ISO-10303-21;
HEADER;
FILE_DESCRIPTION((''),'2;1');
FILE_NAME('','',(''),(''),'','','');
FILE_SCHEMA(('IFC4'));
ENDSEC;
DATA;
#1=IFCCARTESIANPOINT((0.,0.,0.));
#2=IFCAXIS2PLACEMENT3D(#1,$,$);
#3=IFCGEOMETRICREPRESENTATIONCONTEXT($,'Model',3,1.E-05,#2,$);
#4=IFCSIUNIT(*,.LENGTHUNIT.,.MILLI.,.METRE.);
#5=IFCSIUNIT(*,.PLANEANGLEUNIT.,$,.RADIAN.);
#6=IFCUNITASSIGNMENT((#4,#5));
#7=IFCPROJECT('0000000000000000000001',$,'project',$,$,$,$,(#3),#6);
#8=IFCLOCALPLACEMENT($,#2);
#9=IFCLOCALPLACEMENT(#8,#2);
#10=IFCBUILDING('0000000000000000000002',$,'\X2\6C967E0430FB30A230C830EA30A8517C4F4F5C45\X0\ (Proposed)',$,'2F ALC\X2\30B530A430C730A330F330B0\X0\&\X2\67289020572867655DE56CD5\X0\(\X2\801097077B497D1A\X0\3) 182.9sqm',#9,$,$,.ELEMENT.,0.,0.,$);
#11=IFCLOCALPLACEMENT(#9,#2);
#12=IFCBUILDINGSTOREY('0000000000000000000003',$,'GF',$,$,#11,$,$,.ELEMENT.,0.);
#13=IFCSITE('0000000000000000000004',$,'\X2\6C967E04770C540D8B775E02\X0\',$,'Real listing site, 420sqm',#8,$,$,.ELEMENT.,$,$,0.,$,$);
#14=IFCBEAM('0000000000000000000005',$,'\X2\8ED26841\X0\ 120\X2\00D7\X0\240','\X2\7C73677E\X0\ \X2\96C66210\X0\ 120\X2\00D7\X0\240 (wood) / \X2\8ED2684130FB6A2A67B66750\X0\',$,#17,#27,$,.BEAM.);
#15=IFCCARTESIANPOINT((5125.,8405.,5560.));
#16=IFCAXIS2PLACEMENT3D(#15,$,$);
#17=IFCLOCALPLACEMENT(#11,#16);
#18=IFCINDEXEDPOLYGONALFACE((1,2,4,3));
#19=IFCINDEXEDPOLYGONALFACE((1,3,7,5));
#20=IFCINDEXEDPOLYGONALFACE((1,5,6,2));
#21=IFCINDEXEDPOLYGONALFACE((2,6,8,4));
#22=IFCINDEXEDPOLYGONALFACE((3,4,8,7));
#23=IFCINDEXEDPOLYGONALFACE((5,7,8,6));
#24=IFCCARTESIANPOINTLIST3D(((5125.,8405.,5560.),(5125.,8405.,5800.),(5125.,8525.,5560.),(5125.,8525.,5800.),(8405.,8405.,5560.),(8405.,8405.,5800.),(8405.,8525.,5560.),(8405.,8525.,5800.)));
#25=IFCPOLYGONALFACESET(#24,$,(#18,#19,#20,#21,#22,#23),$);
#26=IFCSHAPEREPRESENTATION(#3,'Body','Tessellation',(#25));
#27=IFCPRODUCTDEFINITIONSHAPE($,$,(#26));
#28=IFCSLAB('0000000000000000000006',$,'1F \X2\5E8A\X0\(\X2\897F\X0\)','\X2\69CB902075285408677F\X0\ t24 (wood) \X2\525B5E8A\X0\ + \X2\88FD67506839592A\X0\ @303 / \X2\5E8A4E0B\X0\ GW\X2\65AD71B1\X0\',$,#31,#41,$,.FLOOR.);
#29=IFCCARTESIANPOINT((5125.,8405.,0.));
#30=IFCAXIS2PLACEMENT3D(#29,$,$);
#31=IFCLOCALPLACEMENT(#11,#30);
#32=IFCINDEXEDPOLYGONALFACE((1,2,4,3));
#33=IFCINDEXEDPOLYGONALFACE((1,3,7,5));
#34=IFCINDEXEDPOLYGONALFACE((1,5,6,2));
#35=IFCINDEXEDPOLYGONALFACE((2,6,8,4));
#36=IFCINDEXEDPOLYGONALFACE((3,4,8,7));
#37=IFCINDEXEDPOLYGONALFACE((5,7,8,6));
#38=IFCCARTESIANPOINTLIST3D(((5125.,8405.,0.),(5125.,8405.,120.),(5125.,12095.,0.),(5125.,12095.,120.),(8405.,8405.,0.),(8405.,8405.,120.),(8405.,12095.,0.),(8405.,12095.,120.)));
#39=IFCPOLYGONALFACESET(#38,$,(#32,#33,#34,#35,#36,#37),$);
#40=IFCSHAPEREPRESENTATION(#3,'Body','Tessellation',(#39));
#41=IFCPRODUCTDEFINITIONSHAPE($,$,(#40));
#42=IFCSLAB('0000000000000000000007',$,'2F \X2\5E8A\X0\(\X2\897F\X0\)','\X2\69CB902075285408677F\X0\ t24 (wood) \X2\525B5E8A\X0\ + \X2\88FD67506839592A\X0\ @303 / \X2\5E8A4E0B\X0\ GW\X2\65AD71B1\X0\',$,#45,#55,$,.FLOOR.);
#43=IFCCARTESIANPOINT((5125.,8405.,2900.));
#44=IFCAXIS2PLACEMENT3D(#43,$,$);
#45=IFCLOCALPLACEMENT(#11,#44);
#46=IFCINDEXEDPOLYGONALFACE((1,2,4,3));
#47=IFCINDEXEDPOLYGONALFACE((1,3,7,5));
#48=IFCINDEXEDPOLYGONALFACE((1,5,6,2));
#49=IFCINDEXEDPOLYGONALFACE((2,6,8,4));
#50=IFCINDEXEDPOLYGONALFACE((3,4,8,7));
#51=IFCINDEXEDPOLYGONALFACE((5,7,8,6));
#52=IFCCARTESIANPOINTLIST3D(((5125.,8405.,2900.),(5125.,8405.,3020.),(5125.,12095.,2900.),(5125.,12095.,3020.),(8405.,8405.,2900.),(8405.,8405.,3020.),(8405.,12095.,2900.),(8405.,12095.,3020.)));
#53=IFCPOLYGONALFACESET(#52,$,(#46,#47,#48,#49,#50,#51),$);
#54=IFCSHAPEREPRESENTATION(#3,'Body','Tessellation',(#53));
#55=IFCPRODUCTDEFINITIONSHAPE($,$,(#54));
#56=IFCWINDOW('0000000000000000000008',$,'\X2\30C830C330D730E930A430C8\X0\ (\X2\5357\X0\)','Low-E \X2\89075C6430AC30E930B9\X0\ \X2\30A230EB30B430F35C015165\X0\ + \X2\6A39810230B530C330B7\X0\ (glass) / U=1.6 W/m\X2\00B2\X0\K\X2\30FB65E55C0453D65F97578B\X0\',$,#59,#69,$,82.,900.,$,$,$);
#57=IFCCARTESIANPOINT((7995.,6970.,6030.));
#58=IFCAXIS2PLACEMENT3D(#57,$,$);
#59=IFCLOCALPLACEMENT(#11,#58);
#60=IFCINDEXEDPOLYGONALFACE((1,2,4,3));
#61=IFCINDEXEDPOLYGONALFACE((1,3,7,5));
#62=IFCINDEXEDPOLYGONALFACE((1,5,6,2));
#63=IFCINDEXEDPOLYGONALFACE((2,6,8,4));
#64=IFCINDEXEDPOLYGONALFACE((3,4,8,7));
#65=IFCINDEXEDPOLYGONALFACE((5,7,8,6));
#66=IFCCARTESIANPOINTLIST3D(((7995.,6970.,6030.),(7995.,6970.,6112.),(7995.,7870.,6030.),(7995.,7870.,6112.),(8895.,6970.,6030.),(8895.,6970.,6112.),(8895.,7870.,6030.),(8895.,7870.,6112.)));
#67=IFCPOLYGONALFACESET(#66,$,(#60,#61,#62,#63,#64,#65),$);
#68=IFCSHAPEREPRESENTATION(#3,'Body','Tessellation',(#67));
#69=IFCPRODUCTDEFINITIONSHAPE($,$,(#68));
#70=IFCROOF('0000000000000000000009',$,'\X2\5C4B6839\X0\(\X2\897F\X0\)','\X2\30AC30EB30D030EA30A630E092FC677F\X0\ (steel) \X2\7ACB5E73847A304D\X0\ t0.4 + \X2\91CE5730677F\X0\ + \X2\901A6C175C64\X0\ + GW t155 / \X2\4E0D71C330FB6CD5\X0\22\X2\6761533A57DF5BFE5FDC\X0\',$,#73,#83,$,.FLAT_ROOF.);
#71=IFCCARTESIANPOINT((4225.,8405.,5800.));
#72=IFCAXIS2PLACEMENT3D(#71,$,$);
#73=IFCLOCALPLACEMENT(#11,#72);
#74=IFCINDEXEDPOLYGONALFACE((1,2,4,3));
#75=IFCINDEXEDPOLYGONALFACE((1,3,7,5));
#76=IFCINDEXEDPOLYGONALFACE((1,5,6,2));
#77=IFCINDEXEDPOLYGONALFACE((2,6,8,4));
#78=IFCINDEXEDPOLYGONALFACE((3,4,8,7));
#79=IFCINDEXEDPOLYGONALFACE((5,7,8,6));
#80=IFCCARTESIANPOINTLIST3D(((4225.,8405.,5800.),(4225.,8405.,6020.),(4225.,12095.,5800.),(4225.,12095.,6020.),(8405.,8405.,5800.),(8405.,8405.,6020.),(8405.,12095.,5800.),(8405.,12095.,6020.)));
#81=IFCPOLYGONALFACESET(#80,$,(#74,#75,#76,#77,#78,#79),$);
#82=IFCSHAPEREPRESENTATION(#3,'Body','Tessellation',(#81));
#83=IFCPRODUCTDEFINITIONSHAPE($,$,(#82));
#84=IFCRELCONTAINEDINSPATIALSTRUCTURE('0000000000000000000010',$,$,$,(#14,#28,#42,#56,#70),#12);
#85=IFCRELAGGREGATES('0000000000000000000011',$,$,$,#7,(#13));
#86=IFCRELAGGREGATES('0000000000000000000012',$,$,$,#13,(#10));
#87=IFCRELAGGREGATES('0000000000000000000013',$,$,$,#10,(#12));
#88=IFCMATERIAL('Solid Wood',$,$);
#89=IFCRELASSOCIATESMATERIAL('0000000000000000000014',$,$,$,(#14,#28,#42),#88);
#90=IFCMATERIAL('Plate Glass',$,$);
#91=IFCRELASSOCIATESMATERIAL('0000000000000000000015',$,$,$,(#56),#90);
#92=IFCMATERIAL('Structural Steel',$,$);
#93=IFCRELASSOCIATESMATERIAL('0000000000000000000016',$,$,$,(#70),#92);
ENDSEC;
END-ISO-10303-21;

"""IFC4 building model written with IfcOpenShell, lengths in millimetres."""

from ifc_helpers import new_model, si_unit, frame, frame_2d, origin, place, context, project, spatial, rectangle, extrude, material, element, save


model = new_model("IFC4")

# Units and contexts
model_context = context("Model", 3, precision=1e-05, world=origin())
ifc_project = project(units=[si_unit("LENGTHUNIT", "METRE", prefix="MILLI"), si_unit("PLANEANGLEUNIT", "RADIAN")], contexts=[model_context])

# Site, building, storey
site_placement = place(None, origin())
site = spatial("IfcSite", under=ifc_project, at=site_placement, Name="沖縄県名護市", ObjectType="Real listing site, 420sqm", CompositionType="ELEMENT", RefElevation=0.0)
building_placement = place(site_placement, origin())
building = spatial("IfcBuilding", under=site, at=building_placement, Name="沖縄・アトリエ兼住居 (Proposed)", ObjectType="2F ALCサイディング&木造在来工法(耐震等級3) 182.9sqm", CompositionType="ELEMENT", ElevationOfRefHeight=0.0, ElevationOfTerrain=0.0)
storey_placement = place(building_placement, origin())
storey = spatial("IfcBuildingStorey", under=building, at=storey_placement, Name="GF", CompositionType="ELEMENT", Elevation=0.0)

# Shared definitions
ifc_material_1 = material(Name="Solid Wood")

# Beam
beam_1_placement = place(storey_placement, frame((5125.0, 8405.0, 5560.0)))
element("IfcBeam", 1, at=beam_1_placement, inside=storey, material=ifc_material_1, Name="軒桁 120×240", Description="米松 集成 120×240 (wood) / 軒桁・横架材", PredefinedType="BEAM", context=model_context, shape_type="SweptSolid", body=[
    extrude(rectangle(XDim=3280.0, YDim=120.0, at=frame_2d((1640.0, 60.0))), frame((5125.0, 8405.0, 5560.0)), (0.0, 0.0, 1.0), 240.0),
])

# Slabs
slab_1_placement = place(storey_placement, frame((5125.0, 8405.0, 0.0)))
element("IfcSlab", 2, at=slab_1_placement, inside=storey, material=ifc_material_1, Name="1F 床(西)", Description="構造用合板 t24 (wood) 剛床 + 製材根太 @303 / 床下 GW断熱", PredefinedType="FLOOR", context=model_context, shape_type="SweptSolid", body=[
    extrude(rectangle(XDim=3280.0, YDim=3690.0, at=frame_2d((1640.0, 1845.0))), frame((5125.0, 8405.0, 0.0)), (0.0, 0.0, 1.0), 120.0),
])
slab_2_placement = place(storey_placement, frame((5125.0, 8405.0, 2900.0)))
element("IfcSlab", 3, at=slab_2_placement, inside=storey, material=ifc_material_1, Name="2F 床(西)", Description="構造用合板 t24 (wood) 剛床 + 製材根太 @303 / 床下 GW断熱", PredefinedType="FLOOR", context=model_context, shape_type="SweptSolid", body=[
    extrude(rectangle(XDim=3280.0, YDim=3690.0, at=frame_2d((1640.0, 1845.0))), frame((5125.0, 8405.0, 2900.0)), (0.0, 0.0, 1.0), 120.0),
])

# Window
ifc_material_2 = material(Name="Plate Glass")
window_placement = place(storey_placement, frame((7995.0, 6970.0, 6030.0)))
element("IfcWindow", 4, at=window_placement, inside=storey, material=ifc_material_2, Name="トップライト (南)", Description="Low-E 複層ガラス アルゴン封入 + 樹脂サッシ (glass) / U=1.6 W/m²K・日射取得型", OverallHeight=82.0, OverallWidth=900.0, context=model_context, shape_type="SweptSolid", body=[
    extrude(rectangle(XDim=900.0, YDim=900.0, at=frame_2d((450.0, 450.0))), frame((7995.0, 6970.0, 6030.0)), (0.0, 0.0, 1.0), 82.0),
])

# Roof
ifc_material_3 = material(Name="Structural Steel")
for number, where, name in (
    (5, (4225.0, 8405.0, 5800.0), "屋根(西)"),
):
    element("IfcRoof", number, at=place(storey_placement, frame(where)), inside=storey, material=ifc_material_3, Name=name, Description="ガルバリウム鋼板 (steel) 立平葺き t0.4 + 野地板 + 通気層 + GW t155 / 不燃・法22条区域対応", PredefinedType="FLAT_ROOF", context=model_context, shape_type="SweptSolid", body=[
        extrude(rectangle(XDim=4180.0, YDim=3690.0, at=frame_2d((2090.0, 1845.0))), frame((4225.0, 8405.0, 5800.0)), (0.0, 0.0, 1.0), 220.0),
    ])

save(model, "model.ifc")
